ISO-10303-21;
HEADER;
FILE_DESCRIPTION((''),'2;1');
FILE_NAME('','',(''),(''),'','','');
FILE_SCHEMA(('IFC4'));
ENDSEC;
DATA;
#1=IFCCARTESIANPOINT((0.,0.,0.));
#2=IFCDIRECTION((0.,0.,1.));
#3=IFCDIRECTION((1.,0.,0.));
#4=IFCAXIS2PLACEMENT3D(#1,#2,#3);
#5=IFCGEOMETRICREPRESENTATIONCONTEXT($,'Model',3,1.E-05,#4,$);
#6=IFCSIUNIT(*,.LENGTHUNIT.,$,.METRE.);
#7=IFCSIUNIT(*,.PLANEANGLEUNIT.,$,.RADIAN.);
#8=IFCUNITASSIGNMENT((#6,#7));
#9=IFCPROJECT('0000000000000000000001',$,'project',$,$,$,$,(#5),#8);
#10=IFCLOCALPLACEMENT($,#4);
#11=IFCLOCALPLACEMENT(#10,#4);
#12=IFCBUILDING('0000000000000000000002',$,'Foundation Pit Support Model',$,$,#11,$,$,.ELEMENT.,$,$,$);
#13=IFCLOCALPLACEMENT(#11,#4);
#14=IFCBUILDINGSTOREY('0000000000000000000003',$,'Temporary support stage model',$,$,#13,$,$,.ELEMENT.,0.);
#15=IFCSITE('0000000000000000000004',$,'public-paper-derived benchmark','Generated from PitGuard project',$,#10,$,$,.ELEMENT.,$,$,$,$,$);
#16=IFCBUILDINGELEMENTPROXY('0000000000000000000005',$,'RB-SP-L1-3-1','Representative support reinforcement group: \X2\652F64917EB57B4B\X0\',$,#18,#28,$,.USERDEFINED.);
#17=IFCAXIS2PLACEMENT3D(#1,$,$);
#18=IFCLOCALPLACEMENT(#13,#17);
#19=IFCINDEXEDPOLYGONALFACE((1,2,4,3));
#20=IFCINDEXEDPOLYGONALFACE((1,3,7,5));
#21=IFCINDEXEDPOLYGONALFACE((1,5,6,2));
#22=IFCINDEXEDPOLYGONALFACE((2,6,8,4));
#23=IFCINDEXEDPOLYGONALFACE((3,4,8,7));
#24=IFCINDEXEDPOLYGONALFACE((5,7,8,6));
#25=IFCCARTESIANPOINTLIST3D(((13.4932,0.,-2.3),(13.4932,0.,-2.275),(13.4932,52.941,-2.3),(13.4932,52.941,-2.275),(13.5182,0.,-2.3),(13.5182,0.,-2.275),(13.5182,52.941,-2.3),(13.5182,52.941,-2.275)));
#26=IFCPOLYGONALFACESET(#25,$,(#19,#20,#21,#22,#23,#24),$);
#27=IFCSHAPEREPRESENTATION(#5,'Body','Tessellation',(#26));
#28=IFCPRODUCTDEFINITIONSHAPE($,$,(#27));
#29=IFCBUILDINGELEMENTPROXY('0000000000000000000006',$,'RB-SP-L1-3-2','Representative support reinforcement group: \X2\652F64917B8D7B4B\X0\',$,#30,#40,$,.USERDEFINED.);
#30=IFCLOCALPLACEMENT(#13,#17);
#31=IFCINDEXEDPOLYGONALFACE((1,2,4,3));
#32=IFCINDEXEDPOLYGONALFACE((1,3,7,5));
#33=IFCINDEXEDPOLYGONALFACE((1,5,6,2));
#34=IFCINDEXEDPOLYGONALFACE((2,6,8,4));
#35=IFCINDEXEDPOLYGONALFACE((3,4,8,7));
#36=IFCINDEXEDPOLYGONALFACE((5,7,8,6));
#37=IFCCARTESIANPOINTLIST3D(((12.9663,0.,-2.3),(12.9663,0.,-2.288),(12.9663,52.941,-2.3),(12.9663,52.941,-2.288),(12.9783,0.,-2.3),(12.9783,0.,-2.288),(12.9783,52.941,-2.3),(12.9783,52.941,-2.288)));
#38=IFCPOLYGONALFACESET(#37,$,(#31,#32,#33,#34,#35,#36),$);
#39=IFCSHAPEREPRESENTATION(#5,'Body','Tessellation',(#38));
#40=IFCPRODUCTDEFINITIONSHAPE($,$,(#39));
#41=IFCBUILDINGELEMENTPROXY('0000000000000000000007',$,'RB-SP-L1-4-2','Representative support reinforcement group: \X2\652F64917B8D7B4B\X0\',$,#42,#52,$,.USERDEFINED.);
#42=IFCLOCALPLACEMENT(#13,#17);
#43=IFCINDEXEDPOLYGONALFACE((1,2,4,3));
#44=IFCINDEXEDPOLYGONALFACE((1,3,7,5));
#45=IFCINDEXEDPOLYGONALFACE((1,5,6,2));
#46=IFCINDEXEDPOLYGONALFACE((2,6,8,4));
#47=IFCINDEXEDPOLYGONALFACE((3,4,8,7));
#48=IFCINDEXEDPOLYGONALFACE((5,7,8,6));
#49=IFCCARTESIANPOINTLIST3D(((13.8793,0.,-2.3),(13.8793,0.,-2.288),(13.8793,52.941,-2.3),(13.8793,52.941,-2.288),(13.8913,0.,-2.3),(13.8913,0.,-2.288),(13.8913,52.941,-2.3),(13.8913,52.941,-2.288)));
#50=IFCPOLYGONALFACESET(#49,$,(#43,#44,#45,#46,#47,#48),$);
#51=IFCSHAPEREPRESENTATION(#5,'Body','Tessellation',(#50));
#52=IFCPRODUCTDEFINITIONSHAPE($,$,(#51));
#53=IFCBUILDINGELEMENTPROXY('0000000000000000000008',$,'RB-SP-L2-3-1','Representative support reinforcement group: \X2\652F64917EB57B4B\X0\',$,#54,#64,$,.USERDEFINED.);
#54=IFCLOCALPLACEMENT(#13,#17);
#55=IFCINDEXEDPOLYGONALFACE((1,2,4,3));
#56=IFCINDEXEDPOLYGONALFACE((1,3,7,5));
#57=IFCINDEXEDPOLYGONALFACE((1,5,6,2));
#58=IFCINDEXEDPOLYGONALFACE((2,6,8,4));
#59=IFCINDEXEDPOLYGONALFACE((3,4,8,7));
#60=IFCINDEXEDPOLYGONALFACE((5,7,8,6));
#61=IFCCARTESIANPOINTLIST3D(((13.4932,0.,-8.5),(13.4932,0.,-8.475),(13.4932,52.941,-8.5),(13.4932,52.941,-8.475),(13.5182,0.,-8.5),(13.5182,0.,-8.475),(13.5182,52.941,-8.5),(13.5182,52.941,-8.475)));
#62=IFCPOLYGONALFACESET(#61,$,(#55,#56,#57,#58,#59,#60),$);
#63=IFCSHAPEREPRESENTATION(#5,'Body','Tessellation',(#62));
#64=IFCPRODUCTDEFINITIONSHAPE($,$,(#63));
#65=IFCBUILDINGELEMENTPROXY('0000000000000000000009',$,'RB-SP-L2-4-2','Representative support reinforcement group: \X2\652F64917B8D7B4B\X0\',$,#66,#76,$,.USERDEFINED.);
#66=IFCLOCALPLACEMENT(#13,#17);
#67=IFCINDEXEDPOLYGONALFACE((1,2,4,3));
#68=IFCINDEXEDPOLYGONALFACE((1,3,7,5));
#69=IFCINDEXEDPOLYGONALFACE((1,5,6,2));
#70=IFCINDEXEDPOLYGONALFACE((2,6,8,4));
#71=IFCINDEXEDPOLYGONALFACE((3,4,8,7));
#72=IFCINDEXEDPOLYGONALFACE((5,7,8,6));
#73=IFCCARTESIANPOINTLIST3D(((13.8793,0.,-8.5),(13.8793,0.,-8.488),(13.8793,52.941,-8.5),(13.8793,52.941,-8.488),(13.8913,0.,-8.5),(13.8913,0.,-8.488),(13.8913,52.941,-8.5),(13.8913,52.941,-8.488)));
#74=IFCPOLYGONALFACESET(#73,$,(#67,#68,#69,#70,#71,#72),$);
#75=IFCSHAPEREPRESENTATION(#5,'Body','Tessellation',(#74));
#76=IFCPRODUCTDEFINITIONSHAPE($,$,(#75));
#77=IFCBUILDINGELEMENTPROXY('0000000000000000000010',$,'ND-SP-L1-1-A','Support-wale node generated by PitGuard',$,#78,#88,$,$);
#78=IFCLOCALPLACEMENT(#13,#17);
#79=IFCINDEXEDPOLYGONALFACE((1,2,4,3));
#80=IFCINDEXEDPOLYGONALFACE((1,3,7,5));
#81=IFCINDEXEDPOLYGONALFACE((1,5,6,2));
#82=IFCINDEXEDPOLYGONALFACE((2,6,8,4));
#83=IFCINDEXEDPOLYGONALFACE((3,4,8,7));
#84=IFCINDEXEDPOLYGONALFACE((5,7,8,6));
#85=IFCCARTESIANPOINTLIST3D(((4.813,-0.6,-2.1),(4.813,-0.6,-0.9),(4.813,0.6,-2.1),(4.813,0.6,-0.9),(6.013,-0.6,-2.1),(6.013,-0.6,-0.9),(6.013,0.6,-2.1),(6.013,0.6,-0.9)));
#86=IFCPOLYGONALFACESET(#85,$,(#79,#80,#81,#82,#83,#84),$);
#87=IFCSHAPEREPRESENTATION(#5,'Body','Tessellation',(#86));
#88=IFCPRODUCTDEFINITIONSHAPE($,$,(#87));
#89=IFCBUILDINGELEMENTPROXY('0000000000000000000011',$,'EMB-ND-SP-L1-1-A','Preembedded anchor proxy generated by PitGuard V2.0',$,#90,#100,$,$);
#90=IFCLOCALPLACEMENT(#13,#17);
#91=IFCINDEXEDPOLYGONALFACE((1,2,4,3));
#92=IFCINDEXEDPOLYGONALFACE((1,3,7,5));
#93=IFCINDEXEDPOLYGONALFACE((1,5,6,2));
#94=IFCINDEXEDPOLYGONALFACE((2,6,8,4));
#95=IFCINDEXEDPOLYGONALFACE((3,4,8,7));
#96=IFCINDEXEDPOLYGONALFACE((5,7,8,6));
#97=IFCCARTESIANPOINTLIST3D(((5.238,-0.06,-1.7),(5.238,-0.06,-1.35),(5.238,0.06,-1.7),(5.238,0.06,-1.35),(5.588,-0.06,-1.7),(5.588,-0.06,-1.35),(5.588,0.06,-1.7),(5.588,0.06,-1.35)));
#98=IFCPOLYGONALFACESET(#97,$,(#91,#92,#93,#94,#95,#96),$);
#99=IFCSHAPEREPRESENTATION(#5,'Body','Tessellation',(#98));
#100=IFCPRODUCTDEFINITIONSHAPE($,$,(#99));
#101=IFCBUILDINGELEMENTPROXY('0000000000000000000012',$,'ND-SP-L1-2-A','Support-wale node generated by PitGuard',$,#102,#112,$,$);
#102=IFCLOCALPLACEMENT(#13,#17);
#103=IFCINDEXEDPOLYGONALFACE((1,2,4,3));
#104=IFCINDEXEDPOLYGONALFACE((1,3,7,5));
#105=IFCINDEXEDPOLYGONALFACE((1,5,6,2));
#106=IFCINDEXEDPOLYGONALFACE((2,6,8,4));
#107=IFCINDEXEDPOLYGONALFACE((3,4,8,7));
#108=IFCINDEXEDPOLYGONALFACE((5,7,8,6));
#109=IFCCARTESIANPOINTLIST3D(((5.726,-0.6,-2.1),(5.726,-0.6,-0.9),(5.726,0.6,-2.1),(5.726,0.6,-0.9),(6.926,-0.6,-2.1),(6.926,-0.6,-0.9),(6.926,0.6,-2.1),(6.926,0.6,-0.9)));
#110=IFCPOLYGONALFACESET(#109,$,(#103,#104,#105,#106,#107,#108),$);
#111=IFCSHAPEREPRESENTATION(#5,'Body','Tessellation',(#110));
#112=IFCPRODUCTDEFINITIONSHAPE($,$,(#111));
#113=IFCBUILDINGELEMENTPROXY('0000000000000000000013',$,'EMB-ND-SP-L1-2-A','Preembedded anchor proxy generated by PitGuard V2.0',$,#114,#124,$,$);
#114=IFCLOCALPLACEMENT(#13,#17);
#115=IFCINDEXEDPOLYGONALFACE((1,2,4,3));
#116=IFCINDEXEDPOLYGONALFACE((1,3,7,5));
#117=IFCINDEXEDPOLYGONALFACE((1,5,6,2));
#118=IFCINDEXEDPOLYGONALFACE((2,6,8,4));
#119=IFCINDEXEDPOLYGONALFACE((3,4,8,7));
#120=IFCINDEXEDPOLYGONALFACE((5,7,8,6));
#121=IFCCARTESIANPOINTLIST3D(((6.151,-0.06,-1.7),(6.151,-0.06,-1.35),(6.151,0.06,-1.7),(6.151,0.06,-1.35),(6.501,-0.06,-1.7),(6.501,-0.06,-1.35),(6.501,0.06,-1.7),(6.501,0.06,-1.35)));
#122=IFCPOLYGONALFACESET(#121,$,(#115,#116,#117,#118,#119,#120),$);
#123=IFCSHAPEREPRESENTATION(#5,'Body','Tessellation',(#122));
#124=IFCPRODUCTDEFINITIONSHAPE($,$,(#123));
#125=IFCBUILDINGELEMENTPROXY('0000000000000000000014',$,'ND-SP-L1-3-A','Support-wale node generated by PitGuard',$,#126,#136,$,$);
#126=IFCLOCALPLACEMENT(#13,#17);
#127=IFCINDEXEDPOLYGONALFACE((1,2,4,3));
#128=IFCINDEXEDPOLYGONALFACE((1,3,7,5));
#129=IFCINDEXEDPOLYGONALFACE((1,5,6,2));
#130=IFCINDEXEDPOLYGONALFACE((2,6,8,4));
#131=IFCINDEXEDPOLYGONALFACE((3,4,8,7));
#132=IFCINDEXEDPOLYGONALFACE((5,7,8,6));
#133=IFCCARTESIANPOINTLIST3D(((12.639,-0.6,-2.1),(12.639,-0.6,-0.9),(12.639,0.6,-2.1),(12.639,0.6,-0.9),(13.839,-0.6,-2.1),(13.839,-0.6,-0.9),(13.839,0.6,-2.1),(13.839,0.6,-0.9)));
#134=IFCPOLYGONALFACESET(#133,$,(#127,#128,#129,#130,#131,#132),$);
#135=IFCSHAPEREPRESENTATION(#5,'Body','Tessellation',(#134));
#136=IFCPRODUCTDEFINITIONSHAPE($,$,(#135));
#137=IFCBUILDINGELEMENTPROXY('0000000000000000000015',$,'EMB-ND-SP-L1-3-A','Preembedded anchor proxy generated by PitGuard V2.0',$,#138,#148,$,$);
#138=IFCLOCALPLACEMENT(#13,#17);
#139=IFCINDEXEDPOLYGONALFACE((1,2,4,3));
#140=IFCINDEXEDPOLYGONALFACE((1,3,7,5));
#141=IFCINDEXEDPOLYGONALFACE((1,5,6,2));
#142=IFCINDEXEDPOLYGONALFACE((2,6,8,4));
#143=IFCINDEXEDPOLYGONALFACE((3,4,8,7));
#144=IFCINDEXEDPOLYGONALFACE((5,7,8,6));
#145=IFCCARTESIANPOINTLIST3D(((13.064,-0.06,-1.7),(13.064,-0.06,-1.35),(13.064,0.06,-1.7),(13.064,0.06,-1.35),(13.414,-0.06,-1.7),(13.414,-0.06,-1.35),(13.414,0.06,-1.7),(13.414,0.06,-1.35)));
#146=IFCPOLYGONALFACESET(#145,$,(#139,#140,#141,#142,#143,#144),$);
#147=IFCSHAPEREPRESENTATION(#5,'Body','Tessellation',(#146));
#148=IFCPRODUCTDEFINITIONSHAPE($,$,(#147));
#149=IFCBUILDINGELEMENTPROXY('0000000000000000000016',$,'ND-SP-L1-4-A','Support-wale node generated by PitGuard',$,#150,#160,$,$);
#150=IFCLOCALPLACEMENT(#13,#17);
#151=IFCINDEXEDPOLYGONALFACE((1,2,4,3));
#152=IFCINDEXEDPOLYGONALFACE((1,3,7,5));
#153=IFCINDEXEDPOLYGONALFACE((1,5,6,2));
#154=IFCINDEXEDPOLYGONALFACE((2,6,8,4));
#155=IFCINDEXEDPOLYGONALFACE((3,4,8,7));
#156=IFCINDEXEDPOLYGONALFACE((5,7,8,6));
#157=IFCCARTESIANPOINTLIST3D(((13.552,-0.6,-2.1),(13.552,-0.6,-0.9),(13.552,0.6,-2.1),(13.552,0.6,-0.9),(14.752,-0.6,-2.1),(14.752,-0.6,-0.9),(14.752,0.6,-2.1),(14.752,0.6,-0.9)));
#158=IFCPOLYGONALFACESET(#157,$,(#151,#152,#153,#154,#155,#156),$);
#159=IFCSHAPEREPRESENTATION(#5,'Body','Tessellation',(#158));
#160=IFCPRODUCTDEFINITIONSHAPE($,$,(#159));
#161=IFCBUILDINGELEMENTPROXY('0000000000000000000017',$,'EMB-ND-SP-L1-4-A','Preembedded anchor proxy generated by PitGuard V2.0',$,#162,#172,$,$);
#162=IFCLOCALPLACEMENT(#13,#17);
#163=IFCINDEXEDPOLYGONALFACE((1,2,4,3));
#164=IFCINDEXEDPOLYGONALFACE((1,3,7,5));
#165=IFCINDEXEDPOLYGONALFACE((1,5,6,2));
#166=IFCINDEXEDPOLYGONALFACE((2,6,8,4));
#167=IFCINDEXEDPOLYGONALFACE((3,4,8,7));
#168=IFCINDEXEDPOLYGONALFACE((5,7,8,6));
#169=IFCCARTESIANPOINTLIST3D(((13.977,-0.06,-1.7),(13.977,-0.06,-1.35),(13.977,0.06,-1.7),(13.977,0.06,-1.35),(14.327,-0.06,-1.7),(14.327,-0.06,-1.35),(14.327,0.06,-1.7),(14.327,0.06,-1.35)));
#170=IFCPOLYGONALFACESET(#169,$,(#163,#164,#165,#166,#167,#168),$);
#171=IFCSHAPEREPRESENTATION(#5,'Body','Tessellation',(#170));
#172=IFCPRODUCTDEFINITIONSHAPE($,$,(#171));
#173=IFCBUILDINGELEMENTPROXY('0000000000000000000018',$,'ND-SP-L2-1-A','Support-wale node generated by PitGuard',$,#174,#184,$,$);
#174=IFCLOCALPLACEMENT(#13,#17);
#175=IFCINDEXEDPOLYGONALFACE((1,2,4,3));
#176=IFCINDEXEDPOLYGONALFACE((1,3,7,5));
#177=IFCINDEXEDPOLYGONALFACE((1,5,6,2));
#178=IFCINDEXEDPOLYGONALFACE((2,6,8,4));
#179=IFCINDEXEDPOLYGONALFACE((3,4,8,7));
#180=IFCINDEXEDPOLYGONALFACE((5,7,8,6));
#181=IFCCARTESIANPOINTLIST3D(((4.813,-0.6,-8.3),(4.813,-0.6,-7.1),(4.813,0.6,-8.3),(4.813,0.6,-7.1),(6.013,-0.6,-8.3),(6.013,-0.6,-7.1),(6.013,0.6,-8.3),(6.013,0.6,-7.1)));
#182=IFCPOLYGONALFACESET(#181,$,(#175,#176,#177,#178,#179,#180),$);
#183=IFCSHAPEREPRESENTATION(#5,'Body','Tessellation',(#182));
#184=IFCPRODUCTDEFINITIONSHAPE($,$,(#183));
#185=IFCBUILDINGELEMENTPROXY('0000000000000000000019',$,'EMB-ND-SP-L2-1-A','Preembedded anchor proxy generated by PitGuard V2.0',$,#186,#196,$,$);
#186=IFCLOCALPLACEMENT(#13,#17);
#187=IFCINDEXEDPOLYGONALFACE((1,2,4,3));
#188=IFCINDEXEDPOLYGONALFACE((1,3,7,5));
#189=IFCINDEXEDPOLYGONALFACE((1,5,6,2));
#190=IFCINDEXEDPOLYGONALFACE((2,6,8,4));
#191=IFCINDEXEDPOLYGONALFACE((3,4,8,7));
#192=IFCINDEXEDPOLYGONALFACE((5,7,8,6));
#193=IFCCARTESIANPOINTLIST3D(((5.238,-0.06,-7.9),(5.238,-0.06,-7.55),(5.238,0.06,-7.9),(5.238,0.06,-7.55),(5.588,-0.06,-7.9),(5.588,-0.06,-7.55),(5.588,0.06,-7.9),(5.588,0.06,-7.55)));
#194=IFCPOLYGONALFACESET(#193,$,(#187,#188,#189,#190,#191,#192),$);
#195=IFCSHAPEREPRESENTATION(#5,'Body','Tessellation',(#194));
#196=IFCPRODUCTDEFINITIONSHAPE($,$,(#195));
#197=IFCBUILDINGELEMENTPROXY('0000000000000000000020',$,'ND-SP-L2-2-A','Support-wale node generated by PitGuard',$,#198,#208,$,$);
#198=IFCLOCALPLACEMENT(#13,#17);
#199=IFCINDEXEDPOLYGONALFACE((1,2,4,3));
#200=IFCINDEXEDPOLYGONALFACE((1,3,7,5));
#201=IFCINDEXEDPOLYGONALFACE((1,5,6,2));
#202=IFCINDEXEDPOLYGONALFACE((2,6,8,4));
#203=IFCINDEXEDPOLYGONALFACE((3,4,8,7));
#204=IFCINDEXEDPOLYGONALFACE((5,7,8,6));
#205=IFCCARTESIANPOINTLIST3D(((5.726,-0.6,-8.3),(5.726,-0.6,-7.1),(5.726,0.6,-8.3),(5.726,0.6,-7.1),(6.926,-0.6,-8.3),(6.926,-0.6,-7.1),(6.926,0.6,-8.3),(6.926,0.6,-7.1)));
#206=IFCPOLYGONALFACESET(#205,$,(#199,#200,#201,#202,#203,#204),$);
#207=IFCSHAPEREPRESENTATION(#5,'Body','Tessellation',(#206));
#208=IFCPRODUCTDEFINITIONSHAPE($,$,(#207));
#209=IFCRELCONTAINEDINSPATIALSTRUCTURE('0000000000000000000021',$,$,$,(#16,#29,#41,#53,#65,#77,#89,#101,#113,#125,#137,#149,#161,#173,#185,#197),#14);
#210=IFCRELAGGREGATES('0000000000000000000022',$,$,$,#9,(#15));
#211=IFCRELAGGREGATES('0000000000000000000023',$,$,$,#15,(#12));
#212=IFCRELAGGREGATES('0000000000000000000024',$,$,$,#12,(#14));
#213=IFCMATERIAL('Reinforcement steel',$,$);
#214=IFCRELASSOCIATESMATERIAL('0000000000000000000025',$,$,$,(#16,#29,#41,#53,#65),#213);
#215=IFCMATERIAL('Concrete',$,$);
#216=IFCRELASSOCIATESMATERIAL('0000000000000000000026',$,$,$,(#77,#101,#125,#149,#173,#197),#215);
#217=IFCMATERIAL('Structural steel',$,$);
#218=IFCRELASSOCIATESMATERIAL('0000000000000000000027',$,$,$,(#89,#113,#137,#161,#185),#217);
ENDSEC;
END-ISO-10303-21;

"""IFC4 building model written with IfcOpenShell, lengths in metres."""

from ifc_helpers import new_model, si_unit, frame, origin_with_axes, origin_2d, place, context, project, spatial, rectangle, extrude, material, element, save


model = new_model("IFC4")

# Units and contexts
model_context = context("Model", 3, precision=1e-05, world=origin_with_axes())
ifc_project = project(units=[si_unit("LENGTHUNIT", "METRE"), si_unit("PLANEANGLEUNIT", "RADIAN")], contexts=[model_context])

# Site, building, storey
site_placement = place(None, origin_with_axes())
site = spatial("IfcSite", under=ifc_project, at=site_placement, Name="public-paper-derived benchmark", Description="Generated from PitGuard project", CompositionType="ELEMENT")
building_placement = place(site_placement, origin_with_axes())
building = spatial("IfcBuilding", under=site, at=building_placement, Name="Foundation Pit Support Model", CompositionType="ELEMENT")
storey_placement = place(building_placement, origin_with_axes())
storey = spatial("IfcBuildingStorey", under=building, at=storey_placement, Name="Temporary support stage model", CompositionType="ELEMENT", Elevation=0.0)

# Shared definitions
ifc_material_1 = material(Name="Concrete")

# Shared definitions
ifc_material_2 = material(Name="Structural steel")

# Building element proxies
ifc_material_3 = material(Name="Reinforcement steel")
proxy_1_placement = place(storey_placement, frame((13.5057, 26.4705, -2.3), z_axis=(0.0, 0.0, 1.0), x_axis=(0.0, 1.0, 0.0)))
element("IfcBuildingElementProxy", 1, at=proxy_1_placement, inside=storey, material=ifc_material_3, Name="RB-SP-L1-3-1", Description="Representative support reinforcement group: 支撑纵筋", PredefinedType="USERDEFINED", context=model_context, shape_type="SweptSolid", body=[
    extrude(rectangle(XDim=52.941, YDim=0.025, at=origin_2d()), origin_with_axes(), (0.0, 0.0, 1.0), 0.025),
])
for number, where, z_axis, x_axis, name in (
    (2, (12.9723, 26.4705, -2.3), (0.0, 0.0, 1.0), (0.0, 1.0, 0.0), "RB-SP-L1-3-2"),
    (3, (13.8853, 26.4705, -2.3), (0.0, 0.0, 1.0), (0.0, 1.0, 0.0), "RB-SP-L1-4-2"),
):
    element("IfcBuildingElementProxy", number, at=place(storey_placement, frame(where, z_axis=z_axis, x_axis=x_axis)), inside=storey, material=ifc_material_3, Name=name, Description="Representative support reinforcement group: 支撑箍筋", PredefinedType="USERDEFINED", context=model_context, shape_type="SweptSolid", body=[
        extrude(rectangle(XDim=52.941, YDim=0.012, at=origin_2d()), origin_with_axes(), (0.0, 0.0, 1.0), 0.012),
    ])
proxy_2_placement = place(storey_placement, frame((13.5057, 26.4705, -8.5), z_axis=(0.0, 0.0, 1.0), x_axis=(0.0, 1.0, 0.0)))
element("IfcBuildingElementProxy", 4, at=proxy_2_placement, inside=storey, material=ifc_material_3, Name="RB-SP-L2-3-1", Description="Representative support reinforcement group: 支撑纵筋", PredefinedType="USERDEFINED", context=model_context, shape_type="SweptSolid", body=[
    extrude(rectangle(XDim=52.941, YDim=0.025, at=origin_2d()), origin_with_axes(), (0.0, 0.0, 1.0), 0.025),
])
proxy_3_placement = place(storey_placement, frame((13.8853, 26.4705, -8.5), z_axis=(0.0, 0.0, 1.0), x_axis=(0.0, 1.0, 0.0)))
element("IfcBuildingElementProxy", 5, at=proxy_3_placement, inside=storey, material=ifc_material_3, Name="RB-SP-L2-4-2", Description="Representative support reinforcement group: 支撑箍筋", PredefinedType="USERDEFINED", context=model_context, shape_type="SweptSolid", body=[
    extrude(rectangle(XDim=52.941, YDim=0.012, at=origin_2d()), origin_with_axes(), (0.0, 0.0, 1.0), 0.012),
])
proxy_4_placement = place(storey_placement, frame((5.413, 0.0, -2.1), z_axis=(0.0, 0.0, 1.0), x_axis=(1.0, 0.0, 0.0)))
element("IfcBuildingElementProxy", 6, at=proxy_4_placement, inside=storey, material=ifc_material_1, Name="ND-SP-L1-1-A", Description="Support-wale node generated by PitGuard", context=model_context, shape_type="SweptSolid", body=[
    extrude(rectangle(XDim=1.2, YDim=1.2, at=origin_2d()), origin_with_axes(), (0.0, 0.0, 1.0), 1.2),
])
proxy_5_placement = place(storey_placement, frame((5.413, 0.0, -1.7), z_axis=(0.0, 0.0, 1.0), x_axis=(1.0, 0.0, 0.0)))
element("IfcBuildingElementProxy", 7, at=proxy_5_placement, inside=storey, material=ifc_material_2, Name="EMB-ND-SP-L1-1-A", Description="Preembedded anchor proxy generated by PitGuard V2.0", context=model_context, shape_type="SweptSolid", body=[
    extrude(rectangle(XDim=0.35, YDim=0.12, at=origin_2d()), origin_with_axes(), (0.0, 0.0, 1.0), 0.35),
])
proxy_6_placement = place(storey_placement, frame((6.326, 0.0, -2.1), z_axis=(0.0, 0.0, 1.0), x_axis=(1.0, 0.0, 0.0)))
element("IfcBuildingElementProxy", 8, at=proxy_6_placement, inside=storey, material=ifc_material_1, Name="ND-SP-L1-2-A", Description="Support-wale node generated by PitGuard", context=model_context, shape_type="SweptSolid", body=[
    extrude(rectangle(XDim=1.2, YDim=1.2, at=origin_2d()), origin_with_axes(), (0.0, 0.0, 1.0), 1.2),
])
proxy_7_placement = place(storey_placement, frame((6.326, 0.0, -1.7), z_axis=(0.0, 0.0, 1.0), x_axis=(1.0, 0.0, 0.0)))
element("IfcBuildingElementProxy", 9, at=proxy_7_placement, inside=storey, material=ifc_material_2, Name="EMB-ND-SP-L1-2-A", Description="Preembedded anchor proxy generated by PitGuard V2.0", context=model_context, shape_type="SweptSolid", body=[
    extrude(rectangle(XDim=0.35, YDim=0.12, at=origin_2d()), origin_with_axes(), (0.0, 0.0, 1.0), 0.35),
])
proxy_8_placement = place(storey_placement, frame((13.239, 0.0, -2.1), z_axis=(0.0, 0.0, 1.0), x_axis=(1.0, 0.0, 0.0)))
element("IfcBuildingElementProxy", 10, at=proxy_8_placement, inside=storey, material=ifc_material_1, Name="ND-SP-L1-3-A", Description="Support-wale node generated by PitGuard", context=model_context, shape_type="SweptSolid", body=[
    extrude(rectangle(XDim=1.2, YDim=1.2, at=origin_2d()), origin_with_axes(), (0.0, 0.0, 1.0), 1.2),
])
proxy_9_placement = place(storey_placement, frame((13.239, 0.0, -1.7), z_axis=(0.0, 0.0, 1.0), x_axis=(1.0, 0.0, 0.0)))
element("IfcBuildingElementProxy", 11, at=proxy_9_placement, inside=storey, material=ifc_material_2, Name="EMB-ND-SP-L1-3-A", Description="Preembedded anchor proxy generated by PitGuard V2.0", context=model_context, shape_type="SweptSolid", body=[
    extrude(rectangle(XDim=0.35, YDim=0.12, at=origin_2d()), origin_with_axes(), (0.0, 0.0, 1.0), 0.35),
])
proxy_10_placement = place(storey_placement, frame((14.152, 0.0, -2.1), z_axis=(0.0, 0.0, 1.0), x_axis=(1.0, 0.0, 0.0)))
element("IfcBuildingElementProxy", 12, at=proxy_10_placement, inside=storey, material=ifc_material_1, Name="ND-SP-L1-4-A", Description="Support-wale node generated by PitGuard", context=model_context, shape_type="SweptSolid", body=[
    extrude(rectangle(XDim=1.2, YDim=1.2, at=origin_2d()), origin_with_axes(), (0.0, 0.0, 1.0), 1.2),
])
proxy_11_placement = place(storey_placement, frame((14.152, 0.0, -1.7), z_axis=(0.0, 0.0, 1.0), x_axis=(1.0, 0.0, 0.0)))
element("IfcBuildingElementProxy", 13, at=proxy_11_placement, inside=storey, material=ifc_material_2, Name="EMB-ND-SP-L1-4-A", Description="Preembedded anchor proxy generated by PitGuard V2.0", context=model_context, shape_type="SweptSolid", body=[
    extrude(rectangle(XDim=0.35, YDim=0.12, at=origin_2d()), origin_with_axes(), (0.0, 0.0, 1.0), 0.35),
])
proxy_12_placement = place(storey_placement, frame((5.413, 0.0, -8.3), z_axis=(0.0, 0.0, 1.0), x_axis=(1.0, 0.0, 0.0)))
element("IfcBuildingElementProxy", 14, at=proxy_12_placement, inside=storey, material=ifc_material_1, Name="ND-SP-L2-1-A", Description="Support-wale node generated by PitGuard", context=model_context, shape_type="SweptSolid", body=[
    extrude(rectangle(XDim=1.2, YDim=1.2, at=origin_2d()), origin_with_axes(), (0.0, 0.0, 1.0), 1.2),
])
proxy_13_placement = place(storey_placement, frame((5.413, 0.0, -7.9), z_axis=(0.0, 0.0, 1.0), x_axis=(1.0, 0.0, 0.0)))
element("IfcBuildingElementProxy", 15, at=proxy_13_placement, inside=storey, material=ifc_material_2, Name="EMB-ND-SP-L2-1-A", Description="Preembedded anchor proxy generated by PitGuard V2.0", context=model_context, shape_type="SweptSolid", body=[
    extrude(rectangle(XDim=0.35, YDim=0.12, at=origin_2d()), origin_with_axes(), (0.0, 0.0, 1.0), 0.35),
])
proxy_14_placement = place(storey_placement, frame((6.326, 0.0, -8.3), z_axis=(0.0, 0.0, 1.0), x_axis=(1.0, 0.0, 0.0)))
element("IfcBuildingElementProxy", 16, at=proxy_14_placement, inside=storey, material=ifc_material_1, Name="ND-SP-L2-2-A", Description="Support-wale node generated by PitGuard", context=model_context, shape_type="SweptSolid", body=[
    extrude(rectangle(XDim=1.2, YDim=1.2, at=origin_2d()), origin_with_axes(), (0.0, 0.0, 1.0), 1.2),
])

save(model, "model.ifc")
